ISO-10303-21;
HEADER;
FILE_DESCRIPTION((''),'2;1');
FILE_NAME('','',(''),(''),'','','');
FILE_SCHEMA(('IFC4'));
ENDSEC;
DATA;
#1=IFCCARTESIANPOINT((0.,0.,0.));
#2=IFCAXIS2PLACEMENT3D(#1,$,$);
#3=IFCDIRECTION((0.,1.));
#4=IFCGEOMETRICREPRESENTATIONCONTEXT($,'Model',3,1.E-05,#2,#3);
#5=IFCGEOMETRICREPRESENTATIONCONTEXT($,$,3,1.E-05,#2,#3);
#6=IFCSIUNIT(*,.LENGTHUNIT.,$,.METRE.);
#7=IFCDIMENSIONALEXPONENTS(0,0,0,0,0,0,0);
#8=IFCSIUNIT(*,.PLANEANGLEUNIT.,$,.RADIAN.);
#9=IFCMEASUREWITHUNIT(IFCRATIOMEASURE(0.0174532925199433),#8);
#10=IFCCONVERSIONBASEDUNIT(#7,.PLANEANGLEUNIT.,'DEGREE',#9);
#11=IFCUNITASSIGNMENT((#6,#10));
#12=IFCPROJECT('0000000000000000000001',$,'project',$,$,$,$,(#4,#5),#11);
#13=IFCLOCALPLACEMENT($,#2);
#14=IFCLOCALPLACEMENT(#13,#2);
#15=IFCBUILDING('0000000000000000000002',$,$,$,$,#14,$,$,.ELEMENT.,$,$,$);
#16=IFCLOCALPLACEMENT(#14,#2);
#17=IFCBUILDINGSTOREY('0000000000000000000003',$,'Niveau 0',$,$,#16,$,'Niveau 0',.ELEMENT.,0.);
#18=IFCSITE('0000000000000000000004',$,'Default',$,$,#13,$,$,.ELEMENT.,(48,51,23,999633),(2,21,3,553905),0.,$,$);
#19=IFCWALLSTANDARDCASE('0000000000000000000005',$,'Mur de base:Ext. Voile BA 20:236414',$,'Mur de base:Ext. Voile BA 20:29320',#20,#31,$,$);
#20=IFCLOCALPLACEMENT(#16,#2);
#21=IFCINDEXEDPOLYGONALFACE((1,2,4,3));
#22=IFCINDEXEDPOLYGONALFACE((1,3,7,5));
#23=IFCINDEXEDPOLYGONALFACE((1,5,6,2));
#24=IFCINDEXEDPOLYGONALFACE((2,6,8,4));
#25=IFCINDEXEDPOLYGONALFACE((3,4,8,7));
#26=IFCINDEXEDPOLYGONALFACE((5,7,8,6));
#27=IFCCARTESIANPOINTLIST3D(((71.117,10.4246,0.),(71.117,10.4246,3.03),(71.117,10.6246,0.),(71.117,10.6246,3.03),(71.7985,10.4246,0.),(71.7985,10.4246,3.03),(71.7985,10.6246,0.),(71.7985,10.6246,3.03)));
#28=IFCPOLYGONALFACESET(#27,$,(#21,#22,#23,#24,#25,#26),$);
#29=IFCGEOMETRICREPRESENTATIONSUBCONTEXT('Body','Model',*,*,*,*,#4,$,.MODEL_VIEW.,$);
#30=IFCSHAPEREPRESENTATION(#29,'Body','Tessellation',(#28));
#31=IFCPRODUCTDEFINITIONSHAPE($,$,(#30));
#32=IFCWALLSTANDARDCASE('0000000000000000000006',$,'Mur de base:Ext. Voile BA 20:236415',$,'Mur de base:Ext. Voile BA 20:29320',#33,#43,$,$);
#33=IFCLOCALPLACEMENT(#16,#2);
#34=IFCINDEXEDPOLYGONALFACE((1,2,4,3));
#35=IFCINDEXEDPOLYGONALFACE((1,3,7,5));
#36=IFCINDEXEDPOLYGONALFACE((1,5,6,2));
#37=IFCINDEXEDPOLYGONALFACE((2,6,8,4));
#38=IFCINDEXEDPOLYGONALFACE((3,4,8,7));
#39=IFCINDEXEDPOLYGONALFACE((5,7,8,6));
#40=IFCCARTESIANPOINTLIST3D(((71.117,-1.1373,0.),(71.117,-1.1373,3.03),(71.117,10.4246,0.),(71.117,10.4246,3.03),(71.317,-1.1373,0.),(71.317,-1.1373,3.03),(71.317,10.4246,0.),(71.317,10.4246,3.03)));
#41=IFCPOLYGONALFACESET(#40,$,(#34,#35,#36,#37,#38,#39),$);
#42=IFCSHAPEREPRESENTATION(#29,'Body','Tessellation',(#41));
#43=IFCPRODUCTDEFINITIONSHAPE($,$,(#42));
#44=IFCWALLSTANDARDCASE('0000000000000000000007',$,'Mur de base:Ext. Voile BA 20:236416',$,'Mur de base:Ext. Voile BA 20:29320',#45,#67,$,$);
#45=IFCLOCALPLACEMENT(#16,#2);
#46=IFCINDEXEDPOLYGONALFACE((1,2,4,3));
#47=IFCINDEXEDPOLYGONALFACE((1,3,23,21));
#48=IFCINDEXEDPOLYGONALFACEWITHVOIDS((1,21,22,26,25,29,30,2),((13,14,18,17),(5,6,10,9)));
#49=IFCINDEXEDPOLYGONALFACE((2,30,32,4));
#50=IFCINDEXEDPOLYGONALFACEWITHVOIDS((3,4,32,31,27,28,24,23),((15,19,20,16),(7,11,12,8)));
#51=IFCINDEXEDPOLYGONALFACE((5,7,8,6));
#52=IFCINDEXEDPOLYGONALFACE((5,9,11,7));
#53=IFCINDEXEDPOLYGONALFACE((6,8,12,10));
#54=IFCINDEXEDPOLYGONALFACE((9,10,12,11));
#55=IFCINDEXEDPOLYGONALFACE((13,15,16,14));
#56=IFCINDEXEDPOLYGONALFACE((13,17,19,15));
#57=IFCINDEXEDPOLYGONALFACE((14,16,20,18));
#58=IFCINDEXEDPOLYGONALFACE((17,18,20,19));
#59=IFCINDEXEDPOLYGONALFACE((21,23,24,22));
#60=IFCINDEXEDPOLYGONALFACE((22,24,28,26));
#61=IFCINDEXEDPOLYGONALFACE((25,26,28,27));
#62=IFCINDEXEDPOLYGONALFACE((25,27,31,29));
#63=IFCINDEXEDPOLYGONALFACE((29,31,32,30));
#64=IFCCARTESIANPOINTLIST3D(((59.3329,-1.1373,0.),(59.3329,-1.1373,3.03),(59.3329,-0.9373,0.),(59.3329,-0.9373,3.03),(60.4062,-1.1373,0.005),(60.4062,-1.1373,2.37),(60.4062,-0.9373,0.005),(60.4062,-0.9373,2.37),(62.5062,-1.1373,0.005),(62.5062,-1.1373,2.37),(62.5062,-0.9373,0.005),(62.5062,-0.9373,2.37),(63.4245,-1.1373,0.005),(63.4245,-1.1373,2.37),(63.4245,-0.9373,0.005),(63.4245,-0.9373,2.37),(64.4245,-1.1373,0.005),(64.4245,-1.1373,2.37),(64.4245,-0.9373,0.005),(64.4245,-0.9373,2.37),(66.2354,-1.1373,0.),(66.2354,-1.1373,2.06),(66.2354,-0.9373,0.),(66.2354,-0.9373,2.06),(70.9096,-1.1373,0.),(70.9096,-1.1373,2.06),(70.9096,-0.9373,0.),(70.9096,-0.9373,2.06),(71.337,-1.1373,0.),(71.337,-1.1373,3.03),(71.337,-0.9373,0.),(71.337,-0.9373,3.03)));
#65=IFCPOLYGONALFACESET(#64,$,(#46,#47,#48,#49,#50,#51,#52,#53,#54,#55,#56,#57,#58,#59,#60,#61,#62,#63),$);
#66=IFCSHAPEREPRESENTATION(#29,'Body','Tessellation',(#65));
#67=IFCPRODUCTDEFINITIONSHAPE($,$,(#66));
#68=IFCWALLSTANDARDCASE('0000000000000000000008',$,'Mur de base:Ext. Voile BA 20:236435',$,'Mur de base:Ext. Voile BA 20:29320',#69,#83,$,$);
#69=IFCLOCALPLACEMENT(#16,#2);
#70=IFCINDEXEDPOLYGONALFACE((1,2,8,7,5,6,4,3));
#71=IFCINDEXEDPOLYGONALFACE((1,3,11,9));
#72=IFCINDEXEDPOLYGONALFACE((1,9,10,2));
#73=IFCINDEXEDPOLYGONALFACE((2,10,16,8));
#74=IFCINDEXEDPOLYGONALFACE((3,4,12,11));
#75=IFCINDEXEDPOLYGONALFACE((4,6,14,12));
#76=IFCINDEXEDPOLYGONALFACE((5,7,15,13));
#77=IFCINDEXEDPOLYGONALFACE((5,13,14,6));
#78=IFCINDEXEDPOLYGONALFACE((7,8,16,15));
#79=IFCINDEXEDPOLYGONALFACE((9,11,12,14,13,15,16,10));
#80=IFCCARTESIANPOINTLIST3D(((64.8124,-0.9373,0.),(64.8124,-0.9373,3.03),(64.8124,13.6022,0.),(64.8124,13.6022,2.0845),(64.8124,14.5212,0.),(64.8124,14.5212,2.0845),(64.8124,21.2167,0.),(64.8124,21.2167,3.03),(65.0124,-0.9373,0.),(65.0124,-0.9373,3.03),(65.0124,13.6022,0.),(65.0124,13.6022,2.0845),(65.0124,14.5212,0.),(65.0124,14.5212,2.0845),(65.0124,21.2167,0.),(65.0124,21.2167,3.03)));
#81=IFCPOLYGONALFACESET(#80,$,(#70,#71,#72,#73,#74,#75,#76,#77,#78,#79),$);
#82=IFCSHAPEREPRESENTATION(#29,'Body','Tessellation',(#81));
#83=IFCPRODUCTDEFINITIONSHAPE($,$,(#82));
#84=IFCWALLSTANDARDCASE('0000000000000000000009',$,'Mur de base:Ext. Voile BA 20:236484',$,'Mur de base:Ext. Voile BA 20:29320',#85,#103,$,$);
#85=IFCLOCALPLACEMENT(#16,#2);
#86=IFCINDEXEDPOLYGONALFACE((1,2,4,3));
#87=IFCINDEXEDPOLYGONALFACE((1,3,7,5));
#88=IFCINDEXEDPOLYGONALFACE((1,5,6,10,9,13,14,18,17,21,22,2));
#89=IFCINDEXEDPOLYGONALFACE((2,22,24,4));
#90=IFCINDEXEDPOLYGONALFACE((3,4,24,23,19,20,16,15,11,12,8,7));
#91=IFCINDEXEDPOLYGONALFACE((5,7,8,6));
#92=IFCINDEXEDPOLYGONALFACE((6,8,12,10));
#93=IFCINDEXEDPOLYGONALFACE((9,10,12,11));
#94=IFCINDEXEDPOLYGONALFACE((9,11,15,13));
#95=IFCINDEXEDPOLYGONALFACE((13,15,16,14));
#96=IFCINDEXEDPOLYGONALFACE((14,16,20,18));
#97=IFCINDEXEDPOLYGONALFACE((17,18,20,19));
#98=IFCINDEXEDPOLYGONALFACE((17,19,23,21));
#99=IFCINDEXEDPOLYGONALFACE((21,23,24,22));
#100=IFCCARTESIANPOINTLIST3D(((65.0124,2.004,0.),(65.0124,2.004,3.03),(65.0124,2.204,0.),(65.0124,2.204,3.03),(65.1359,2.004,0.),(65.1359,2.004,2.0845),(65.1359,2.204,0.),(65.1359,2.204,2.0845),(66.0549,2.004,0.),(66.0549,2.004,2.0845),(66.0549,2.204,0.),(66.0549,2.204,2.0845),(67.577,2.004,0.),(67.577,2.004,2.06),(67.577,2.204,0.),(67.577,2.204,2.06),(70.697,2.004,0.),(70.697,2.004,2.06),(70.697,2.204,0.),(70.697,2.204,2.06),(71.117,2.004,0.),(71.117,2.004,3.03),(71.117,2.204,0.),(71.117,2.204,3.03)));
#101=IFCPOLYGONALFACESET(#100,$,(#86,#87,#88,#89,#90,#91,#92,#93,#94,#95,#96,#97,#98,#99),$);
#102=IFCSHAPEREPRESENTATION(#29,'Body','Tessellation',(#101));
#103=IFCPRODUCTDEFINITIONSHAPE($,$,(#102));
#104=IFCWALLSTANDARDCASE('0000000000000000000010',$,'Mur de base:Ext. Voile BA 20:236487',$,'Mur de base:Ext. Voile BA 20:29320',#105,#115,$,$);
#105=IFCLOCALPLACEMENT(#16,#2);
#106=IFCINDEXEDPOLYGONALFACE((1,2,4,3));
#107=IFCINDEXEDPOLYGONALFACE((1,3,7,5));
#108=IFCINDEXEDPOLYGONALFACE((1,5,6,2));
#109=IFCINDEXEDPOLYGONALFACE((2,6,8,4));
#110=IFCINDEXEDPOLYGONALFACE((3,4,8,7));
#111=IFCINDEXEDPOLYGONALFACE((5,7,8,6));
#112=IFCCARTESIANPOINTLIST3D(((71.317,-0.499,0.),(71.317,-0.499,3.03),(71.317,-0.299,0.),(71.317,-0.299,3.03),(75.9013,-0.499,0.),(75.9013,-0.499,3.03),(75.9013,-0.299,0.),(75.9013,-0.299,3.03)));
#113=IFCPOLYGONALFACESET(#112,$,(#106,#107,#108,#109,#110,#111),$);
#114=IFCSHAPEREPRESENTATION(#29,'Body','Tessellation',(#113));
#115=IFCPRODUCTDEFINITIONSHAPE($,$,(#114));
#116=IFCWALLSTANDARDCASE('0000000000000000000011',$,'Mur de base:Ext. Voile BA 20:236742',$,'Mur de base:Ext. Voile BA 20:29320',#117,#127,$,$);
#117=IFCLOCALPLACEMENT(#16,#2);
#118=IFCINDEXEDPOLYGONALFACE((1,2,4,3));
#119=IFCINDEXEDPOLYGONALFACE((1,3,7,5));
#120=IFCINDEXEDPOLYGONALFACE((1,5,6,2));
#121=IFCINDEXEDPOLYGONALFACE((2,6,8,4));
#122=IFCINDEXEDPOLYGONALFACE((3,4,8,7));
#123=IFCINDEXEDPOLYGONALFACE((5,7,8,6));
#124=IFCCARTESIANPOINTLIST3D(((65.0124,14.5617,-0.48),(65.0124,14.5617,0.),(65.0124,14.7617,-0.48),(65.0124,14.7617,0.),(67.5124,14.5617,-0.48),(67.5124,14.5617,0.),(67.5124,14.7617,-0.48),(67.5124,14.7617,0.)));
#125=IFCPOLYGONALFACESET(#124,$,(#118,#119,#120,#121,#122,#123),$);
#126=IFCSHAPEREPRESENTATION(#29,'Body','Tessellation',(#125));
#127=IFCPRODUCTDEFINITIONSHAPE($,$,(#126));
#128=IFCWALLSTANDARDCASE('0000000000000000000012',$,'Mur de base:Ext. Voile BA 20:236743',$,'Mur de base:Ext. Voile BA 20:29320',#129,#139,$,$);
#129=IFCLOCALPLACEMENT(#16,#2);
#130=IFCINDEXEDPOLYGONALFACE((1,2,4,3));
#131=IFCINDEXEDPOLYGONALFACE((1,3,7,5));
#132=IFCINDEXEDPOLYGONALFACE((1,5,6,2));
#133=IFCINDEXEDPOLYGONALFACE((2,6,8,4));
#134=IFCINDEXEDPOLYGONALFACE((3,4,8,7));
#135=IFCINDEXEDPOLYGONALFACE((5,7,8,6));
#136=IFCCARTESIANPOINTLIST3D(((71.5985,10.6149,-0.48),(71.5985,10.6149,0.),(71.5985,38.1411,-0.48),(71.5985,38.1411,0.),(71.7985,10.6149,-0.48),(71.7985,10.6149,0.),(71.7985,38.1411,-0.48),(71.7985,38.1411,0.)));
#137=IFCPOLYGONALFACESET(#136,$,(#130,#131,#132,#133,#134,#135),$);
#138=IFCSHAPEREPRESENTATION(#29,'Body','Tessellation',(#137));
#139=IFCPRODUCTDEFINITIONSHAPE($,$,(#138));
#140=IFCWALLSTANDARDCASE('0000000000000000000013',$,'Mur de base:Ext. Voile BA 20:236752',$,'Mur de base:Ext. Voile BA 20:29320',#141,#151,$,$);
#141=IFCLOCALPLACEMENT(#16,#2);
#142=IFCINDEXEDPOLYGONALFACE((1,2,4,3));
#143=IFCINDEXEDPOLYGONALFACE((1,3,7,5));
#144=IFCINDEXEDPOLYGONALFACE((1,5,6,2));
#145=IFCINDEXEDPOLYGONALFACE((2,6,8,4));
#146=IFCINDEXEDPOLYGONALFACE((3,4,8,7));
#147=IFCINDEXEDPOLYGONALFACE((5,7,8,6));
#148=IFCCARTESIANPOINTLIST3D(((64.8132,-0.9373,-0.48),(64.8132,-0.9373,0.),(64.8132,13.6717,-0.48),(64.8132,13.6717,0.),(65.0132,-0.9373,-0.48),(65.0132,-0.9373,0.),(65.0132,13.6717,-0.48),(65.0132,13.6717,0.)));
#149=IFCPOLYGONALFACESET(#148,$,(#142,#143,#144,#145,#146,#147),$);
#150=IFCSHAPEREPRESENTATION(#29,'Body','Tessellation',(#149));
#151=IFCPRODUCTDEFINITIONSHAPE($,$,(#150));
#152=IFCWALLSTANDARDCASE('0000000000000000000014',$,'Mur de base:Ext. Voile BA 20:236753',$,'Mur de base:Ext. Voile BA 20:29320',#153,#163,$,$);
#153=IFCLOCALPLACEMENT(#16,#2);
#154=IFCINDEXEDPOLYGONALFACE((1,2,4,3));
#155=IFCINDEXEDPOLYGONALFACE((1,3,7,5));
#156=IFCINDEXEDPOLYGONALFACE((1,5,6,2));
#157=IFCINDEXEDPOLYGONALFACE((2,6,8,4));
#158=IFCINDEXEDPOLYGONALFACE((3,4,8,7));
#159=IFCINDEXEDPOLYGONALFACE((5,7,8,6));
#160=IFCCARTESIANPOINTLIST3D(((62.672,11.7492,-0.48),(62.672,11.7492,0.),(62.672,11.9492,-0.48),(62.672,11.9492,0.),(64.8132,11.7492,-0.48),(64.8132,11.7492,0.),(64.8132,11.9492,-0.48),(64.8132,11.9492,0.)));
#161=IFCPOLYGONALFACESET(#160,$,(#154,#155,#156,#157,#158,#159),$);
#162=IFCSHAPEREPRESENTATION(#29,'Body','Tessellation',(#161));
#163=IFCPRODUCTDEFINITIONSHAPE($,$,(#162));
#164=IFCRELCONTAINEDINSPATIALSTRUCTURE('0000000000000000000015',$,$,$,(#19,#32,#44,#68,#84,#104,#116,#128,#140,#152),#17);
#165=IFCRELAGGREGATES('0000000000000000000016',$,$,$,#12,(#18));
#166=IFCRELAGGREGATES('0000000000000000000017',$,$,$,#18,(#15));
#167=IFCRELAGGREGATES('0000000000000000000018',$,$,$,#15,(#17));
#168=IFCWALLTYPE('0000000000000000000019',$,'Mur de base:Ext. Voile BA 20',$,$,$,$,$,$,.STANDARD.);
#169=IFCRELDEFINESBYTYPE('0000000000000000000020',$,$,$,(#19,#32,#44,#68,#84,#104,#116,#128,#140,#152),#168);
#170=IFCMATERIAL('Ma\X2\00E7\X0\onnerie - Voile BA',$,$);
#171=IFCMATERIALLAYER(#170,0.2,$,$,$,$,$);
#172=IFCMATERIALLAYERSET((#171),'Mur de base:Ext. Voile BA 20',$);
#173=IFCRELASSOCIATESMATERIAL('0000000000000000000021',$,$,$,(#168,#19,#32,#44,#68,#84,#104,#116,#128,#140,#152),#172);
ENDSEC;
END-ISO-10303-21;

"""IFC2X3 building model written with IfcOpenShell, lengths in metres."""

from ifc_helpers import new_model, entity, si_unit, converted_unit, direction, frame, frame_2d, origin, origin_2d_with_axis, place, context, subcontext, project, spatial, rectangle, extrude, material, layer, layer_set, layer_usage, type_object, element, save


model = new_model("IFC2X3")

# Units and contexts
model_context = context("Model", 3, precision=1e-05, world=origin(), true_north=direction((0.0, 1.0)))
context_of_model = context(None, 3, precision=1e-05, world=origin(), true_north=direction((0.0, 1.0)))
body_context = subcontext(model_context, "Body", "Model", "MODEL_VIEW")
ifc_project = project(units=[si_unit("LENGTHUNIT", "METRE"), converted_unit("PLANEANGLEUNIT", "DEGREE", entity("IfcRatioMeasure", 0.0174532925199433), si_unit("PLANEANGLEUNIT", "RADIAN"), dimensions=[0, 0, 0, 0, 0, 0, 0])], contexts=[model_context, context_of_model])

# Site, building, storey
site_placement = place(None, origin())
site = spatial("IfcSite", under=ifc_project, at=site_placement, Name="Default", CompositionType="ELEMENT", RefLatitude=(48, 51, 23, 999633), RefLongitude=(2, 21, 3, 553905), RefElevation=0.0)
building_placement = place(site_placement, origin())
building = spatial("IfcBuilding", under=site, at=building_placement, CompositionType="ELEMENT")
storey_placement = place(building_placement, origin())
storey = spatial("IfcBuildingStorey", under=building, at=storey_placement, Name="Niveau 0", LongName="Niveau 0", CompositionType="ELEMENT", Elevation=0.0)

# Walls
ifc_material = material(Name="Maçonnerie - Voile BA")
ifc_layer = layer(ifc_material, 0.2)
ifc_layer_set = layer_set([ifc_layer], Name="Mur de base:Ext. Voile BA 20")
ifc_layer_usage_1 = layer_usage(ifc_layer_set, "AXIS2", "NEGATIVE", 0.1)
wall_type = type_object("IfcWallType", Name="Mur de base:Ext. Voile BA 20", PredefinedType="STANDARD", material=ifc_layer_set)
wall_1_placement = place(storey_placement, frame((71.7985, 10.5246, 0.0), z_axis=(0.0, 0.0, 1.0), x_axis=(-1.0, 0.0, 0.0)))
element("IfcWallStandardCase", 1, at=wall_1_placement, inside=storey, type_object=wall_type, material=ifc_layer_usage_1, Name="Mur de base:Ext. Voile BA 20:236414", ObjectType="Mur de base:Ext. Voile BA 20:29320", context=body_context, shape_type="SweptSolid", body=[
    extrude(rectangle(XDim=0.6815, YDim=0.2, at=frame_2d((0.3407, 0.0), x_axis=(-1.0, 0.0))), origin(), (0.0, 0.0, 1.0), 3.03),
])
ifc_layer_usage_2 = layer_usage(ifc_layer_set, "AXIS2", "NEGATIVE", 0.1)
wall_2_placement = place(storey_placement, frame((71.217, 10.4246, 0.0), z_axis=(0.0, 0.0, 1.0), x_axis=(0.0, -1.0, 0.0)))
element("IfcWallStandardCase", 2, at=wall_2_placement, inside=storey, type_object=wall_type, material=ifc_layer_usage_2, Name="Mur de base:Ext. Voile BA 20:236415", ObjectType="Mur de base:Ext. Voile BA 20:29320", context=body_context, shape_type="SweptSolid", body=[
    extrude(rectangle(XDim=11.5619, YDim=0.2, at=frame_2d((5.781, 0.0), x_axis=(-1.0, 0.0))), origin(), (0.0, 0.0, 1.0), 3.03),
])

# Wall, openings
ifc_layer_usage_3 = layer_usage(ifc_layer_set, "AXIS2", "NEGATIVE", 0.1)
wall_3_placement = place(storey_placement, frame((71.337, -1.0373, 0.0), z_axis=(0.0, 0.0, 1.0), x_axis=(-1.0, 0.0, 0.0)))
wall_3 = element("IfcWallStandardCase", 3, at=wall_3_placement, inside=storey, type_object=wall_type, material=ifc_layer_usage_3, Name="Mur de base:Ext. Voile BA 20:236416", ObjectType="Mur de base:Ext. Voile BA 20:29320", context=body_context, shape_type="SweptSolid", body=[
    extrude(rectangle(XDim=12.0041, YDim=0.2, at=frame_2d((6.0021, 0.0), x_axis=(-1.0, 0.0))), origin(), (0.0, 0.0, 1.0), 3.03),
])
opening_1_placement = place(wall_3_placement, origin())
element("IfcOpeningElement", 4, at=opening_1_placement, cuts=wall_3, ObjectType="Opening", context=body_context, shape_type="SweptSolid", body=[
    extrude(rectangle(XDim=2.365, YDim=2.1, at=frame_2d((0.0, 0.0), x_axis=(1.0, 0.0))), frame((9.8809, -0.1, 1.1875), z_axis=(0.0, 1.0, 0.0), x_axis=(0.0, 0.0, -1.0)), (0.0, 0.0, 1.0), 0.2),
])
opening_2_placement = place(wall_3_placement, origin())
element("IfcOpeningElement", 5, at=opening_2_placement, cuts=wall_3, ObjectType="Opening", context=body_context, shape_type="SweptSolid", body=[
    extrude(rectangle(XDim=2.365, YDim=1.0, at=origin_2d_with_axis()), frame((7.4125, -0.1, 1.1875), z_axis=(0.0, 1.0, 0.0), x_axis=(0.0, 0.0, -1.0)), (0.0, 0.0, 1.0), 0.2),
])
opening_3_placement = place(wall_3_placement, origin())
element("IfcOpeningElement", 6, at=opening_3_placement, cuts=wall_3, ObjectType="Opening", context=body_context, shape_type="SweptSolid", body=[
    extrude(rectangle(XDim=2.06, YDim=4.6742, at=frame_2d((0.0, 0.0), x_axis=(0.0, 1.0))), frame((2.7645, 0.1, 1.03), z_axis=(0.0, -1.0, 0.0), x_axis=(1.0, 0.0, 0.0)), (0.0, 0.0, 1.0), 0.2),
])

# Wall, opening
ifc_layer_usage_4 = layer_usage(ifc_layer_set, "AXIS2", "NEGATIVE", 0.1)
wall_4_placement = place(storey_placement, frame((64.9124, -0.9373, 0.0), z_axis=(0.0, 0.0, 1.0), x_axis=(0.0, 1.0, 0.0)))
wall_4 = element("IfcWallStandardCase", 7, at=wall_4_placement, inside=storey, type_object=wall_type, material=ifc_layer_usage_4, Name="Mur de base:Ext. Voile BA 20:236435", ObjectType="Mur de base:Ext. Voile BA 20:29320", context=body_context, shape_type="SweptSolid", body=[
    extrude(rectangle(XDim=22.154, YDim=0.2, at=frame_2d((11.077, 0.0), x_axis=(-1.0, 0.0))), origin(), (0.0, 0.0, 1.0), 3.03),
])
opening_4_placement = place(wall_4_placement, origin())
element("IfcOpeningElement", 8, at=opening_4_placement, cuts=wall_4, ObjectType="Opening", context=body_context, shape_type="SweptSolid", body=[
    extrude(rectangle(XDim=2.0845, YDim=0.919, at=origin_2d_with_axis()), frame((14.999, -0.1, 1.0422), z_axis=(0.0, 1.0, 0.0), x_axis=(0.0, 0.0, -1.0)), (0.0, 0.0, 1.0), 0.2),
])

# Wall, openings
ifc_layer_usage_5 = layer_usage(ifc_layer_set, "AXIS2", "NEGATIVE", 0.1)
wall_5_placement = place(storey_placement, frame((65.0124, 2.104, 0.0)))
wall_5 = element("IfcWallStandardCase", 9, at=wall_5_placement, inside=storey, type_object=wall_type, material=ifc_layer_usage_5, Name="Mur de base:Ext. Voile BA 20:236484", ObjectType="Mur de base:Ext. Voile BA 20:29320", context=body_context, shape_type="SweptSolid", body=[
    extrude(rectangle(XDim=6.1046, YDim=0.2, at=frame_2d((3.0523, 0.0), x_axis=(-1.0, 0.0))), origin(), (0.0, 0.0, 1.0), 3.03),
])
opening_5_placement = place(wall_5_placement, origin())
element("IfcOpeningElement", 10, at=opening_5_placement, cuts=wall_5, ObjectType="Opening", context=body_context, shape_type="SweptSolid", body=[
    extrude(rectangle(XDim=2.06, YDim=3.12, at=frame_2d((0.0, 0.0), x_axis=(1.0, 0.0))), frame((4.1246, -0.1, 1.03), z_axis=(0.0, 1.0, 0.0), x_axis=(0.0, 0.0, -1.0)), (0.0, 0.0, 1.0), 0.2),
])
opening_6_placement = place(wall_5_placement, origin())
element("IfcOpeningElement", 11, at=opening_6_placement, cuts=wall_5, ObjectType="Opening", context=body_context, shape_type="SweptSolid", body=[
    extrude(rectangle(XDim=2.0845, YDim=0.919, at=origin_2d_with_axis()), frame((0.583, -0.1, 1.0422), z_axis=(0.0, 1.0, 0.0), x_axis=(0.0, 0.0, -1.0)), (0.0, 0.0, 1.0), 0.2),
])

# Walls
ifc_layer_usage_6 = layer_usage(ifc_layer_set, "AXIS2", "POSITIVE", -0.1)
wall_6_placement = place(storey_placement, frame((71.317, -0.399, 0.0)))
element("IfcWallStandardCase", 12, at=wall_6_placement, inside=storey, type_object=wall_type, material=ifc_layer_usage_6, Name="Mur de base:Ext. Voile BA 20:236487", ObjectType="Mur de base:Ext. Voile BA 20:29320", context=body_context, shape_type="SweptSolid", body=[
    extrude(rectangle(XDim=4.5843, YDim=0.2, at=frame_2d((2.2921, 0.0), x_axis=(-1.0, 0.0))), origin(), (0.0, 0.0, 1.0), 3.03),
])
ifc_layer_usage_7 = layer_usage(ifc_layer_set, "AXIS2", "NEGATIVE", 0.1)
wall_7_placement = place(storey_placement, frame((67.5124, 14.6617, -0.48), z_axis=(0.0, 0.0, 1.0), x_axis=(-1.0, 0.0, 0.0)))
element("IfcWallStandardCase", 13, at=wall_7_placement, inside=storey, type_object=wall_type, material=ifc_layer_usage_7, Name="Mur de base:Ext. Voile BA 20:236742", ObjectType="Mur de base:Ext. Voile BA 20:29320", context=body_context, shape_type="SweptSolid", body=[
    extrude(rectangle(XDim=2.5001, YDim=0.2, at=frame_2d((1.25, 0.0), x_axis=(-1.0, 0.0))), origin(), (0.0, 0.0, 1.0), 0.48),
])
ifc_layer_usage_8 = layer_usage(ifc_layer_set, "AXIS2", "NEGATIVE", 0.1)
wall_8_placement = place(storey_placement, frame((71.6985, 10.6149, -0.48), z_axis=(0.0, 0.0, 1.0), x_axis=(0.0, 1.0, 0.0)))
element("IfcWallStandardCase", 14, at=wall_8_placement, inside=storey, type_object=wall_type, material=ifc_layer_usage_8, Name="Mur de base:Ext. Voile BA 20:236743", ObjectType="Mur de base:Ext. Voile BA 20:29320", context=body_context, shape_type="SweptSolid", body=[
    extrude(rectangle(XDim=27.5263, YDim=0.2, at=frame_2d((13.7631, 0.0), x_axis=(-1.0, 0.0))), origin(), (0.0, 0.0, 1.0), 0.48),
])
ifc_layer_usage_9 = layer_usage(ifc_layer_set, "AXIS2", "NEGATIVE", 0.1)
wall_9_placement = place(storey_placement, frame((64.9132, -0.9373, -0.48), z_axis=(0.0, 0.0, 1.0), x_axis=(0.0, 1.0, 0.0)))
element("IfcWallStandardCase", 15, at=wall_9_placement, inside=storey, type_object=wall_type, material=ifc_layer_usage_9, Name="Mur de base:Ext. Voile BA 20:236752", ObjectType="Mur de base:Ext. Voile BA 20:29320", context=body_context, shape_type="SweptSolid", body=[
    extrude(rectangle(XDim=14.609, YDim=0.2, at=frame_2d((7.3045, 0.0), x_axis=(-1.0, 0.0))), origin(), (0.0, 0.0, 1.0), 0.48),
])
ifc_layer_usage_10 = layer_usage(ifc_layer_set, "AXIS2", "NEGATIVE", 0.1)
wall_10_placement = place(storey_placement, frame((64.8132, 11.8492, -0.48), z_axis=(0.0, 0.0, 1.0), x_axis=(-1.0, 0.0, 0.0)))
element("IfcWallStandardCase", 16, at=wall_10_placement, inside=storey, type_object=wall_type, material=ifc_layer_usage_10, Name="Mur de base:Ext. Voile BA 20:236753", ObjectType="Mur de base:Ext. Voile BA 20:29320", context=body_context, shape_type="SweptSolid", body=[
    extrude(rectangle(XDim=2.1412, YDim=0.2, at=frame_2d((1.0706, 0.0), x_axis=(-1.0, 0.0))), origin(), (0.0, 0.0, 1.0), 0.48),
])

save(model, "model.ifc")
